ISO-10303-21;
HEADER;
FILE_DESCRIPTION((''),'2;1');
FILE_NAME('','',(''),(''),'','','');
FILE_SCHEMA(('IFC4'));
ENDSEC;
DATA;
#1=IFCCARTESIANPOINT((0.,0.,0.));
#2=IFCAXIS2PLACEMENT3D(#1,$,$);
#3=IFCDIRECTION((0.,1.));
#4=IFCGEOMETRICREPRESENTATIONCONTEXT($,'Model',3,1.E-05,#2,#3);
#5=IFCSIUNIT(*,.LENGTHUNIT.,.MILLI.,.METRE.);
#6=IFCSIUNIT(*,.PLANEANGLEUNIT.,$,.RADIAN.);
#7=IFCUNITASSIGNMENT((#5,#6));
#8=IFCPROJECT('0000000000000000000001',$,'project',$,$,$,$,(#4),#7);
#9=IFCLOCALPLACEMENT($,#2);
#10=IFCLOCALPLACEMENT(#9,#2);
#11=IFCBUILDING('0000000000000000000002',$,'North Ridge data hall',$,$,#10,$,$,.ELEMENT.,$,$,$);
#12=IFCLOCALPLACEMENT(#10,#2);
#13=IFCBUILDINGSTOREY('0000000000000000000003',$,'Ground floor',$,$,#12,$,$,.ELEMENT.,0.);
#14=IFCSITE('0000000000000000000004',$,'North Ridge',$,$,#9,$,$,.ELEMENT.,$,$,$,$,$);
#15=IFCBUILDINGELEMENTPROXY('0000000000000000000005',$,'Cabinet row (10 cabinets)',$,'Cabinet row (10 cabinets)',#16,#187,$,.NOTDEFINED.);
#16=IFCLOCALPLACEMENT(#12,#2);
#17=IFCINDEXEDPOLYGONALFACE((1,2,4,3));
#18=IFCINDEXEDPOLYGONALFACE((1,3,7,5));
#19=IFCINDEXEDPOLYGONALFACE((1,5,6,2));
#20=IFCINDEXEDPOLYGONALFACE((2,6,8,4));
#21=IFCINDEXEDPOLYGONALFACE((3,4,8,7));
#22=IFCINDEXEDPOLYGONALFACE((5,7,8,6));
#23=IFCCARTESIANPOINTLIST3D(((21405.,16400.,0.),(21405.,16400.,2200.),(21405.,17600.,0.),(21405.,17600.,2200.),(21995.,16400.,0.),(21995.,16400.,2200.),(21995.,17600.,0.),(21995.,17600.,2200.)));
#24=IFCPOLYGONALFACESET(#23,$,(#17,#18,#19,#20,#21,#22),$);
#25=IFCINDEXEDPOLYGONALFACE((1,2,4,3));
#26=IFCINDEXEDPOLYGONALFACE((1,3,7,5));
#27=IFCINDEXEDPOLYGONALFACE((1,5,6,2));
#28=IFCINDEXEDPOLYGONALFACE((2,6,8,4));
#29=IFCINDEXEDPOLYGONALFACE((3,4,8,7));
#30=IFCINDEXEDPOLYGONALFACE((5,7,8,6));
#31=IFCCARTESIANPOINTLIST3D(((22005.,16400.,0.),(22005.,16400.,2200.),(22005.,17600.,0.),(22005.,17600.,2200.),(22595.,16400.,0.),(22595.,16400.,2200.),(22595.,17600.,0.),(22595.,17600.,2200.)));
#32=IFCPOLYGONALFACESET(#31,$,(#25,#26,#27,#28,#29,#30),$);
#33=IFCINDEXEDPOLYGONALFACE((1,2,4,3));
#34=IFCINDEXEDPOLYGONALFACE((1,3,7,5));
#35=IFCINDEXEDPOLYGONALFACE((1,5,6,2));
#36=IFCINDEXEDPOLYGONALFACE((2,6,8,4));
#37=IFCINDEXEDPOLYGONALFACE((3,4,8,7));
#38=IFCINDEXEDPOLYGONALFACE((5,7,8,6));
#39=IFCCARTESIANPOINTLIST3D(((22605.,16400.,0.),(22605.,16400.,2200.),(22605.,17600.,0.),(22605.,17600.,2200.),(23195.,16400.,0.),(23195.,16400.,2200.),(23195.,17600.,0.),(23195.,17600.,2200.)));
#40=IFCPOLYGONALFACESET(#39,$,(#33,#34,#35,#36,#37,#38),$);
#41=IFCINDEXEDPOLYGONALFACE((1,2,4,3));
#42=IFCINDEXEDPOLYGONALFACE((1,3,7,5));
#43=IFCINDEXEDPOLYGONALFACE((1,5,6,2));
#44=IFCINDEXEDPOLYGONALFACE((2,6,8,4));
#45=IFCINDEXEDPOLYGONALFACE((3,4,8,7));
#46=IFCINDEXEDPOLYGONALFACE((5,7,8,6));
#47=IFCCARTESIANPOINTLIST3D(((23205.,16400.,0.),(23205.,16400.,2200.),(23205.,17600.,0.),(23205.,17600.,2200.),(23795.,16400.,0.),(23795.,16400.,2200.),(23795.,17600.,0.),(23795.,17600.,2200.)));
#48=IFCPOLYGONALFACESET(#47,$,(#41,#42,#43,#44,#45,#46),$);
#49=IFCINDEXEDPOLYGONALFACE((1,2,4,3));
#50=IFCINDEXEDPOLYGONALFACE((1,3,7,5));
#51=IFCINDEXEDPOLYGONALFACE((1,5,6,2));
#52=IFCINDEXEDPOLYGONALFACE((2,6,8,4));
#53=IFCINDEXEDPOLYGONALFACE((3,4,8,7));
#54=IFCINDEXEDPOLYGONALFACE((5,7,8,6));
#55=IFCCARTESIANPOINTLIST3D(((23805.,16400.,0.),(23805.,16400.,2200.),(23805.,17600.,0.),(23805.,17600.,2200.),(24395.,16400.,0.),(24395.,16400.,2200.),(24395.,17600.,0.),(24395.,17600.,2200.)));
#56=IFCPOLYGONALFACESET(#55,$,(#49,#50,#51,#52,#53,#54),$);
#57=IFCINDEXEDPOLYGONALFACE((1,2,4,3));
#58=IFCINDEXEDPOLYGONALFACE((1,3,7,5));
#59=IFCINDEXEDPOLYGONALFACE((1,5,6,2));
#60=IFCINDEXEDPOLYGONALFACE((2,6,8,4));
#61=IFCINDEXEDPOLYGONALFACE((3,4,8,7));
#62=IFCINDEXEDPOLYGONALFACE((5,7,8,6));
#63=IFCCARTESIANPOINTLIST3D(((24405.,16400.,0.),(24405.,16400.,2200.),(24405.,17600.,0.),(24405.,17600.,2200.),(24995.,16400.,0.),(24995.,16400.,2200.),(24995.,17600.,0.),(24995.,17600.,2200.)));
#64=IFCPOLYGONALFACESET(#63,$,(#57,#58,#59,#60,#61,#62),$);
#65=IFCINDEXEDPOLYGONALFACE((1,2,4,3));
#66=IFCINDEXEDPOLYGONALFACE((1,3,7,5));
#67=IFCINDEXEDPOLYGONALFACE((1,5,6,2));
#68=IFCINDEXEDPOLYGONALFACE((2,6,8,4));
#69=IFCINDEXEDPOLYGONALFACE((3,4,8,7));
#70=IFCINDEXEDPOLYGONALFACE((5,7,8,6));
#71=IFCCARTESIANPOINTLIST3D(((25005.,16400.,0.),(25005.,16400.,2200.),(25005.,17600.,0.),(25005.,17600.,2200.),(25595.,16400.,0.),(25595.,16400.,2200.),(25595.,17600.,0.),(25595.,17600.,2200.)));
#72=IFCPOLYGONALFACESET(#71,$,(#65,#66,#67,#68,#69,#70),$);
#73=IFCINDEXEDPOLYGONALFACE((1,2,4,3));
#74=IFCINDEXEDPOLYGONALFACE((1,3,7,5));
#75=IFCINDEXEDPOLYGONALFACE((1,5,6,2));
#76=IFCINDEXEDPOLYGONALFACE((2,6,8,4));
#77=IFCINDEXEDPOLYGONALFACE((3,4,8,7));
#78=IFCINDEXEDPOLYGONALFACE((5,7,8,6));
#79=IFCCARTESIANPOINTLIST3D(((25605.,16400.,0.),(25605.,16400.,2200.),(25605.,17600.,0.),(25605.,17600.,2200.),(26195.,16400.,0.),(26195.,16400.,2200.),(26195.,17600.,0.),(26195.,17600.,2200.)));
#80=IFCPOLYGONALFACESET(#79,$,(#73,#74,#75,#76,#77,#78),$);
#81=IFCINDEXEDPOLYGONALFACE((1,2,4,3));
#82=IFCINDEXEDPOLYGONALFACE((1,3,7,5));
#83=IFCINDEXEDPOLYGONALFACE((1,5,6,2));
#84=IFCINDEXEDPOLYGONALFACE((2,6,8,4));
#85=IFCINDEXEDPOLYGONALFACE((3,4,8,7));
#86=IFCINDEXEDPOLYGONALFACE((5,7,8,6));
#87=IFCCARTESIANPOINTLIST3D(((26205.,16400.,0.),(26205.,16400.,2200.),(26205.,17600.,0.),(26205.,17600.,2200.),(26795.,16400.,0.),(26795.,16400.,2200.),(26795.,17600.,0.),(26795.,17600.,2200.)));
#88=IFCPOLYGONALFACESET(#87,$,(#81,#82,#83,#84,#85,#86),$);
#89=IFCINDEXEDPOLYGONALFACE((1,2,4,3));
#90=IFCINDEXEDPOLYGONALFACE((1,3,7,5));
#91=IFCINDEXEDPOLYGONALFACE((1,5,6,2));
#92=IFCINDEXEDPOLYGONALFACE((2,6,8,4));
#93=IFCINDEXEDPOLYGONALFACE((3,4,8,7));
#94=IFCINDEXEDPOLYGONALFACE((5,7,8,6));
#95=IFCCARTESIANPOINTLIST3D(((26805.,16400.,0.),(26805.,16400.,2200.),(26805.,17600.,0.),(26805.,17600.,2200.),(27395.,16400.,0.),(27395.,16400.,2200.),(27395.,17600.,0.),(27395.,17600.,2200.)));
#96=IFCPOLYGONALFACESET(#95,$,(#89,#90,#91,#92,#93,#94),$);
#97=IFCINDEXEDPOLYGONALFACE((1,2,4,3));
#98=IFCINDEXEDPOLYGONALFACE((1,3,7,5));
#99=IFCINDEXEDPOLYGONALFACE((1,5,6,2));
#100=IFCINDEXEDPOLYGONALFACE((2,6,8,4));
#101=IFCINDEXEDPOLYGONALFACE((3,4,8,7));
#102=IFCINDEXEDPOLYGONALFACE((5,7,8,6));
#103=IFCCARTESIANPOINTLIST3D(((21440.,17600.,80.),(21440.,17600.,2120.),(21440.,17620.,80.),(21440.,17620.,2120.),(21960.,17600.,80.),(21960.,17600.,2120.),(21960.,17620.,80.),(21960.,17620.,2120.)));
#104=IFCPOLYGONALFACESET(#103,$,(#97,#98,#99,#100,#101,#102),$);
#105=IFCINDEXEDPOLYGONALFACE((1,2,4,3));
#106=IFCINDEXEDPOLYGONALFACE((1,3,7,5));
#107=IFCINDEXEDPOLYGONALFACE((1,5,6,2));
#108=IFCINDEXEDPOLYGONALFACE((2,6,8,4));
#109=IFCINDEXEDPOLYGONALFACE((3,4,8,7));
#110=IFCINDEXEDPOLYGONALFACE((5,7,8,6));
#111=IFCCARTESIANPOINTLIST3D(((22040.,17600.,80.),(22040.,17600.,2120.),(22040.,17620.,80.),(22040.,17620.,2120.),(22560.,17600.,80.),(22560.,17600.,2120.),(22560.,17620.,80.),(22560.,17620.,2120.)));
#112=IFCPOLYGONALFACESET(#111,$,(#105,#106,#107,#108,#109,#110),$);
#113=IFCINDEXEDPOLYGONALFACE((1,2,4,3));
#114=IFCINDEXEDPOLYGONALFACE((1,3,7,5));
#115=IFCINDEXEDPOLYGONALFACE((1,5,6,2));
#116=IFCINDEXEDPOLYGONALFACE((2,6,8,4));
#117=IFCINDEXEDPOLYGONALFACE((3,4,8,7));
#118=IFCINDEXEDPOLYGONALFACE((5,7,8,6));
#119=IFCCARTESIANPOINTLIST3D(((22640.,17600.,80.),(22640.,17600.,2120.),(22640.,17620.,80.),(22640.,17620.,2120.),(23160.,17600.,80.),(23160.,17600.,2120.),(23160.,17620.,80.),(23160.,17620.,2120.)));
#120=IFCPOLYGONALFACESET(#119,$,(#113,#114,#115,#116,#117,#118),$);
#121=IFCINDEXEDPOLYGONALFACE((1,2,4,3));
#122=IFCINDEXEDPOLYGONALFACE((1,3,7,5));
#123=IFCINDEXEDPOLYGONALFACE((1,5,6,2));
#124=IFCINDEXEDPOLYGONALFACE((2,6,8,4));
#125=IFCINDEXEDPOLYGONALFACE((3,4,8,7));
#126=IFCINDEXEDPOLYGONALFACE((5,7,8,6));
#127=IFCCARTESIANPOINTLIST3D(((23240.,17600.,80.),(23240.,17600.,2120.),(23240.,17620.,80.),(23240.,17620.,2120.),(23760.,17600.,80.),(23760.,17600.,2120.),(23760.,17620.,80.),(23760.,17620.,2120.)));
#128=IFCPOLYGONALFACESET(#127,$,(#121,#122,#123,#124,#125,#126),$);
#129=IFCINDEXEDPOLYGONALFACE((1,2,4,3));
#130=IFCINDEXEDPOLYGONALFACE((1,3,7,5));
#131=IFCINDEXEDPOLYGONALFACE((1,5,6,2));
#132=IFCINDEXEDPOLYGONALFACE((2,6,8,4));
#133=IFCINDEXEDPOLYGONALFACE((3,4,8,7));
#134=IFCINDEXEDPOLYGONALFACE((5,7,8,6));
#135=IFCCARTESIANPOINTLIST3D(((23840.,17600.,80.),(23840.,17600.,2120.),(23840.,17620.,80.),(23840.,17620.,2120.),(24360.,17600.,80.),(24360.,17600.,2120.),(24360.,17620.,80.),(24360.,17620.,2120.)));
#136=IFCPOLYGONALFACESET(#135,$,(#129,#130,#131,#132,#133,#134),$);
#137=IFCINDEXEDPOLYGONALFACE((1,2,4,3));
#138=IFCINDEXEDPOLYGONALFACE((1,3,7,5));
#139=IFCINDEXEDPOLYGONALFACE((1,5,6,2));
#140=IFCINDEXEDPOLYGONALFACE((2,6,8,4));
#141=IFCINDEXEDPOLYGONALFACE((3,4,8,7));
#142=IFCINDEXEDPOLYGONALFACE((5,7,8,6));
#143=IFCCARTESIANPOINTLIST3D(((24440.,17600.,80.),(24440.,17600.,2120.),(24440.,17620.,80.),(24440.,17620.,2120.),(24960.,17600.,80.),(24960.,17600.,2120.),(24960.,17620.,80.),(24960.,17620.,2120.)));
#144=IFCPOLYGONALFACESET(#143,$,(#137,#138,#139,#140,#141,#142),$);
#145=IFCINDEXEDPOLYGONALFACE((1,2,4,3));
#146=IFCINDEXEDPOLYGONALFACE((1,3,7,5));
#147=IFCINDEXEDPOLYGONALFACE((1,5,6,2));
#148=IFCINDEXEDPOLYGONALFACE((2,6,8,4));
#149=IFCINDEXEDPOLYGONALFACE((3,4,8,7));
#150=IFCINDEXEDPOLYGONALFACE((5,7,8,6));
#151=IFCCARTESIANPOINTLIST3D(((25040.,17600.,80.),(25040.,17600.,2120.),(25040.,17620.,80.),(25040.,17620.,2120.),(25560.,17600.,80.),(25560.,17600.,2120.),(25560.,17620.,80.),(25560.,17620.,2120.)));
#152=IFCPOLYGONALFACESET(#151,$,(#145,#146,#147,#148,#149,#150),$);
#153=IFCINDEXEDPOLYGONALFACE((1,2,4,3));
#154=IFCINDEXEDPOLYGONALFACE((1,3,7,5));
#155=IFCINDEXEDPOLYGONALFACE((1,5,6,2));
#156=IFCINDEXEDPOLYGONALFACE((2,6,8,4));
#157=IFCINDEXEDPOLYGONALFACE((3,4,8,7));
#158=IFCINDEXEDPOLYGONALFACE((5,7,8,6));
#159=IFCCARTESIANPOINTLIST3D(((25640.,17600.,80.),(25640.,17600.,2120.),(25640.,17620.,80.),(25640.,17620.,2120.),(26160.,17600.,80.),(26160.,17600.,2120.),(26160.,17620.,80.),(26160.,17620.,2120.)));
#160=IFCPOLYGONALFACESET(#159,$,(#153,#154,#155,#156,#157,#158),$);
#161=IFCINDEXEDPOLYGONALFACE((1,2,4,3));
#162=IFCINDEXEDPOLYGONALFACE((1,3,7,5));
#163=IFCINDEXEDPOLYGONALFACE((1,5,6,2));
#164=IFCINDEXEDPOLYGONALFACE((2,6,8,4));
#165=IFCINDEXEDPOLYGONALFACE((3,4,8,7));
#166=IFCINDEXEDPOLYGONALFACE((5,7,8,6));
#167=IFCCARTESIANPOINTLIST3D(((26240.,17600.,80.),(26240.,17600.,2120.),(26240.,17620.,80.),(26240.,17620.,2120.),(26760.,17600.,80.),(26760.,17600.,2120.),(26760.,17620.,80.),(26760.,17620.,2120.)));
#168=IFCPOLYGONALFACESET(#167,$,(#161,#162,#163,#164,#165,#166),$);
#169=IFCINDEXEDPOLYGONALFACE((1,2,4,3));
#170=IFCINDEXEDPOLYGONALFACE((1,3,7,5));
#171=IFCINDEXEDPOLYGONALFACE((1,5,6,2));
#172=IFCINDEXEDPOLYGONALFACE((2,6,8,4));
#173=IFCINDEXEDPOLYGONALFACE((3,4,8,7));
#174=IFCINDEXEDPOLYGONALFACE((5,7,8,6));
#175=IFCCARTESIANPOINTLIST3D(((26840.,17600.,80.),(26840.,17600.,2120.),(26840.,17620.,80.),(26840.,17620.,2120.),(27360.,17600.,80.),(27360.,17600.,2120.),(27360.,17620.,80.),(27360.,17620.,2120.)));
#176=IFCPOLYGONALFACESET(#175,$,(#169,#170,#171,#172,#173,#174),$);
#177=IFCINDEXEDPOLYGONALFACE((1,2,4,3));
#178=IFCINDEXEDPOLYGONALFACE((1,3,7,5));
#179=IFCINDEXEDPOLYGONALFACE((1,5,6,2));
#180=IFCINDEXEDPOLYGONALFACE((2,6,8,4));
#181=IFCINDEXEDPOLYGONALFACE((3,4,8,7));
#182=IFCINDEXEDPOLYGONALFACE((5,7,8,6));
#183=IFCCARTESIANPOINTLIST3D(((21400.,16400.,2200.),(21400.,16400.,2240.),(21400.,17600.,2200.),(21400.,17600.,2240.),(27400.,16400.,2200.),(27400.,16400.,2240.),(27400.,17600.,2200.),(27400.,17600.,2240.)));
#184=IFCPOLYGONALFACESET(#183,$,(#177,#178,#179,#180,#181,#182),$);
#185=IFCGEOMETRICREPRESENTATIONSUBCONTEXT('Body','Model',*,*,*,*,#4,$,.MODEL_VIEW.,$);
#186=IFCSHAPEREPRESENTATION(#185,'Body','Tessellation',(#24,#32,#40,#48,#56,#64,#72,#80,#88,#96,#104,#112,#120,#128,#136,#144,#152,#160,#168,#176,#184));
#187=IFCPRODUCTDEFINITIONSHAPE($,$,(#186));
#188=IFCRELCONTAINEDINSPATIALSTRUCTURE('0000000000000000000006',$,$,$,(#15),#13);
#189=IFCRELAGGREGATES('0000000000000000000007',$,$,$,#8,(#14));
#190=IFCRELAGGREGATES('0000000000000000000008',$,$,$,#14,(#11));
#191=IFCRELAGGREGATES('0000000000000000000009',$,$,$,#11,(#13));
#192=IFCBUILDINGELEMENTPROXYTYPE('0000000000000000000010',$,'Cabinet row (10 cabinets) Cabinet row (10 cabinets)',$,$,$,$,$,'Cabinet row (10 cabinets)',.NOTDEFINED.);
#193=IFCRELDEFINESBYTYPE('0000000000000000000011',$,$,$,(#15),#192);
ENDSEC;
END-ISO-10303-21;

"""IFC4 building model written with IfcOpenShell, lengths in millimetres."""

from ifc_helpers import new_model, si_unit, direction, frame, origin, place, context, subcontext, project, spatial, polyline, outline, extrude, source, transform, mapped, type_object, type_shapes, element, save


model = new_model("IFC4")

# Units and contexts
model_context = context("Model", 3, precision=1e-05, world=origin(), true_north=direction((0.0, 1.0)))
body_context = subcontext(model_context, "Body", "Model", "MODEL_VIEW")
ifc_project = project(units=[si_unit("LENGTHUNIT", "METRE", prefix="MILLI"), si_unit("PLANEANGLEUNIT", "RADIAN")], contexts=[model_context])

# Site, building, storey
site_placement = place(None, origin())
site = spatial("IfcSite", under=ifc_project, at=site_placement, Name="North Ridge", CompositionType="ELEMENT")
building_placement = place(site_placement, origin())
building = spatial("IfcBuilding", under=site, at=building_placement, Name="North Ridge data hall", CompositionType="ELEMENT")
storey_placement = place(building_placement, origin())
storey = spatial("IfcBuildingStorey", under=building, at=storey_placement, Name="Ground floor", CompositionType="ELEMENT", Elevation=0.0)

# Building element proxy
building_element_proxy_type_1 = type_object("IfcBuildingElementProxyType", Name="Cabinet row (10 cabinets) Cabinet row (10 cabinets)", ElementType="Cabinet row (10 cabinets)", PredefinedType="NOTDEFINED")
shared_shape_1 = source(origin(), body_context, "Body", "SweptSolid", [
    extrude(outline(polyline([(5.0, 0.0), (595.0, 0.0), (595.0, 1200.0), (5.0, 1200.0), (5.0, 0.0)])), origin(), (0.0, 0.0, 1.0), 2200.0),
    extrude(outline(polyline([(605.0, 0.0), (1195.0, 0.0), (1195.0, 1200.0), (605.0, 1200.0), (605.0, 0.0)])), origin(), (0.0, 0.0, 1.0), 2200.0),
    extrude(outline(polyline([(1205.0, 0.0), (1795.0, 0.0), (1795.0, 1200.0), (1205.0, 1200.0), (1205.0, 0.0)])), origin(), (0.0, 0.0, 1.0), 2200.0),
    extrude(outline(polyline([(1805.0, 0.0), (2395.0, 0.0), (2395.0, 1200.0), (1805.0, 1200.0), (1805.0, 0.0)])), origin(), (0.0, 0.0, 1.0), 2200.0),
    extrude(outline(polyline([(2405.0, 0.0), (2995.0, 0.0), (2995.0, 1200.0), (2405.0, 1200.0), (2405.0, 0.0)])), origin(), (0.0, 0.0, 1.0), 2200.0),
    extrude(outline(polyline([(3005.0, 0.0), (3595.0, 0.0), (3595.0, 1200.0), (3005.0, 1200.0), (3005.0, 0.0)])), origin(), (0.0, 0.0, 1.0), 2200.0),
    extrude(outline(polyline([(3605.0, 0.0), (4195.0, 0.0), (4195.0, 1200.0), (3605.0, 1200.0), (3605.0, 0.0)])), origin(), (0.0, 0.0, 1.0), 2200.0),
    extrude(outline(polyline([(4205.0, 0.0), (4795.0, 0.0), (4795.0, 1200.0), (4205.0, 1200.0), (4205.0, 0.0)])), origin(), (0.0, 0.0, 1.0), 2200.0),
    extrude(outline(polyline([(4805.0, 0.0), (5395.0, 0.0), (5395.0, 1200.0), (4805.0, 1200.0), (4805.0, 0.0)])), origin(), (0.0, 0.0, 1.0), 2200.0),
    extrude(outline(polyline([(5405.0, 0.0), (5995.0, 0.0), (5995.0, 1200.0), (5405.0, 1200.0), (5405.0, 0.0)])), origin(), (0.0, 0.0, 1.0), 2200.0),
    extrude(outline(polyline([(40.0, 1200.0), (560.0, 1200.0), (560.0, 1220.0), (40.0, 1220.0), (40.0, 1200.0)])), frame((0.0, 0.0, 80.0)), (0.0, 0.0, 1.0), 2040.0),
    extrude(outline(polyline([(640.0, 1200.0), (1160.0, 1200.0), (1160.0, 1220.0), (640.0, 1220.0), (640.0, 1200.0)])), frame((0.0, 0.0, 80.0)), (0.0, 0.0, 1.0), 2040.0),
    extrude(outline(polyline([(1240.0, 1200.0), (1760.0, 1200.0), (1760.0, 1220.0), (1240.0, 1220.0), (1240.0, 1200.0)])), frame((0.0, 0.0, 80.0)), (0.0, 0.0, 1.0), 2040.0),
    extrude(outline(polyline([(1840.0, 1200.0), (2360.0, 1200.0), (2360.0, 1220.0), (1840.0, 1220.0), (1840.0, 1200.0)])), frame((0.0, 0.0, 80.0)), (0.0, 0.0, 1.0), 2040.0),
    extrude(outline(polyline([(2440.0, 1200.0), (2960.0, 1200.0), (2960.0, 1220.0), (2440.0, 1220.0), (2440.0, 1200.0)])), frame((0.0, 0.0, 80.0)), (0.0, 0.0, 1.0), 2040.0),
    extrude(outline(polyline([(3040.0, 1200.0), (3560.0, 1200.0), (3560.0, 1220.0), (3040.0, 1220.0), (3040.0, 1200.0)])), frame((0.0, 0.0, 80.0)), (0.0, 0.0, 1.0), 2040.0),
    extrude(outline(polyline([(3640.0, 1200.0), (4160.0, 1200.0), (4160.0, 1220.0), (3640.0, 1220.0), (3640.0, 1200.0)])), frame((0.0, 0.0, 80.0)), (0.0, 0.0, 1.0), 2040.0),
    extrude(outline(polyline([(4240.0, 1200.0), (4760.0, 1200.0), (4760.0, 1220.0), (4240.0, 1220.0), (4240.0, 1200.0)])), frame((0.0, 0.0, 80.0)), (0.0, 0.0, 1.0), 2040.0),
    extrude(outline(polyline([(4840.0, 1200.0), (5360.0, 1200.0), (5360.0, 1220.0), (4840.0, 1220.0), (4840.0, 1200.0)])), frame((0.0, 0.0, 80.0)), (0.0, 0.0, 1.0), 2040.0),
    extrude(outline(polyline([(5440.0, 1200.0), (5960.0, 1200.0), (5960.0, 1220.0), (5440.0, 1220.0), (5440.0, 1200.0)])), frame((0.0, 0.0, 80.0)), (0.0, 0.0, 1.0), 2040.0),
    extrude(outline(polyline([(0.0, 0.0), (6000.0, 0.0), (6000.0, 1200.0), (0.0, 1200.0), (0.0, 0.0)])), frame((0.0, 0.0, 2200.0)), (0.0, 0.0, 1.0), 40.0),
])
type_shapes(building_element_proxy_type_1, [shared_shape_1])
for number, where, z_axis, x_axis, name in (
    (1, (21400.0, 16400.0, 0.0), (0.0, 0.0, 1.0), (1.0, 0.0, 0.0), "Cabinet row (10 cabinets)"),
):
    element("IfcBuildingElementProxy", number, at=place(storey_placement, frame(where, z_axis=z_axis, x_axis=x_axis)), inside=storey, type_object=building_element_proxy_type_1, Name=name, ObjectType="Cabinet row (10 cabinets)", PredefinedType="NOTDEFINED", context=body_context, shape_type="MappedRepresentation", body=[
        mapped(shared_shape_1, transform((0.0, 0.0, 0.0))),
    ])

save(model, "model.ifc")
